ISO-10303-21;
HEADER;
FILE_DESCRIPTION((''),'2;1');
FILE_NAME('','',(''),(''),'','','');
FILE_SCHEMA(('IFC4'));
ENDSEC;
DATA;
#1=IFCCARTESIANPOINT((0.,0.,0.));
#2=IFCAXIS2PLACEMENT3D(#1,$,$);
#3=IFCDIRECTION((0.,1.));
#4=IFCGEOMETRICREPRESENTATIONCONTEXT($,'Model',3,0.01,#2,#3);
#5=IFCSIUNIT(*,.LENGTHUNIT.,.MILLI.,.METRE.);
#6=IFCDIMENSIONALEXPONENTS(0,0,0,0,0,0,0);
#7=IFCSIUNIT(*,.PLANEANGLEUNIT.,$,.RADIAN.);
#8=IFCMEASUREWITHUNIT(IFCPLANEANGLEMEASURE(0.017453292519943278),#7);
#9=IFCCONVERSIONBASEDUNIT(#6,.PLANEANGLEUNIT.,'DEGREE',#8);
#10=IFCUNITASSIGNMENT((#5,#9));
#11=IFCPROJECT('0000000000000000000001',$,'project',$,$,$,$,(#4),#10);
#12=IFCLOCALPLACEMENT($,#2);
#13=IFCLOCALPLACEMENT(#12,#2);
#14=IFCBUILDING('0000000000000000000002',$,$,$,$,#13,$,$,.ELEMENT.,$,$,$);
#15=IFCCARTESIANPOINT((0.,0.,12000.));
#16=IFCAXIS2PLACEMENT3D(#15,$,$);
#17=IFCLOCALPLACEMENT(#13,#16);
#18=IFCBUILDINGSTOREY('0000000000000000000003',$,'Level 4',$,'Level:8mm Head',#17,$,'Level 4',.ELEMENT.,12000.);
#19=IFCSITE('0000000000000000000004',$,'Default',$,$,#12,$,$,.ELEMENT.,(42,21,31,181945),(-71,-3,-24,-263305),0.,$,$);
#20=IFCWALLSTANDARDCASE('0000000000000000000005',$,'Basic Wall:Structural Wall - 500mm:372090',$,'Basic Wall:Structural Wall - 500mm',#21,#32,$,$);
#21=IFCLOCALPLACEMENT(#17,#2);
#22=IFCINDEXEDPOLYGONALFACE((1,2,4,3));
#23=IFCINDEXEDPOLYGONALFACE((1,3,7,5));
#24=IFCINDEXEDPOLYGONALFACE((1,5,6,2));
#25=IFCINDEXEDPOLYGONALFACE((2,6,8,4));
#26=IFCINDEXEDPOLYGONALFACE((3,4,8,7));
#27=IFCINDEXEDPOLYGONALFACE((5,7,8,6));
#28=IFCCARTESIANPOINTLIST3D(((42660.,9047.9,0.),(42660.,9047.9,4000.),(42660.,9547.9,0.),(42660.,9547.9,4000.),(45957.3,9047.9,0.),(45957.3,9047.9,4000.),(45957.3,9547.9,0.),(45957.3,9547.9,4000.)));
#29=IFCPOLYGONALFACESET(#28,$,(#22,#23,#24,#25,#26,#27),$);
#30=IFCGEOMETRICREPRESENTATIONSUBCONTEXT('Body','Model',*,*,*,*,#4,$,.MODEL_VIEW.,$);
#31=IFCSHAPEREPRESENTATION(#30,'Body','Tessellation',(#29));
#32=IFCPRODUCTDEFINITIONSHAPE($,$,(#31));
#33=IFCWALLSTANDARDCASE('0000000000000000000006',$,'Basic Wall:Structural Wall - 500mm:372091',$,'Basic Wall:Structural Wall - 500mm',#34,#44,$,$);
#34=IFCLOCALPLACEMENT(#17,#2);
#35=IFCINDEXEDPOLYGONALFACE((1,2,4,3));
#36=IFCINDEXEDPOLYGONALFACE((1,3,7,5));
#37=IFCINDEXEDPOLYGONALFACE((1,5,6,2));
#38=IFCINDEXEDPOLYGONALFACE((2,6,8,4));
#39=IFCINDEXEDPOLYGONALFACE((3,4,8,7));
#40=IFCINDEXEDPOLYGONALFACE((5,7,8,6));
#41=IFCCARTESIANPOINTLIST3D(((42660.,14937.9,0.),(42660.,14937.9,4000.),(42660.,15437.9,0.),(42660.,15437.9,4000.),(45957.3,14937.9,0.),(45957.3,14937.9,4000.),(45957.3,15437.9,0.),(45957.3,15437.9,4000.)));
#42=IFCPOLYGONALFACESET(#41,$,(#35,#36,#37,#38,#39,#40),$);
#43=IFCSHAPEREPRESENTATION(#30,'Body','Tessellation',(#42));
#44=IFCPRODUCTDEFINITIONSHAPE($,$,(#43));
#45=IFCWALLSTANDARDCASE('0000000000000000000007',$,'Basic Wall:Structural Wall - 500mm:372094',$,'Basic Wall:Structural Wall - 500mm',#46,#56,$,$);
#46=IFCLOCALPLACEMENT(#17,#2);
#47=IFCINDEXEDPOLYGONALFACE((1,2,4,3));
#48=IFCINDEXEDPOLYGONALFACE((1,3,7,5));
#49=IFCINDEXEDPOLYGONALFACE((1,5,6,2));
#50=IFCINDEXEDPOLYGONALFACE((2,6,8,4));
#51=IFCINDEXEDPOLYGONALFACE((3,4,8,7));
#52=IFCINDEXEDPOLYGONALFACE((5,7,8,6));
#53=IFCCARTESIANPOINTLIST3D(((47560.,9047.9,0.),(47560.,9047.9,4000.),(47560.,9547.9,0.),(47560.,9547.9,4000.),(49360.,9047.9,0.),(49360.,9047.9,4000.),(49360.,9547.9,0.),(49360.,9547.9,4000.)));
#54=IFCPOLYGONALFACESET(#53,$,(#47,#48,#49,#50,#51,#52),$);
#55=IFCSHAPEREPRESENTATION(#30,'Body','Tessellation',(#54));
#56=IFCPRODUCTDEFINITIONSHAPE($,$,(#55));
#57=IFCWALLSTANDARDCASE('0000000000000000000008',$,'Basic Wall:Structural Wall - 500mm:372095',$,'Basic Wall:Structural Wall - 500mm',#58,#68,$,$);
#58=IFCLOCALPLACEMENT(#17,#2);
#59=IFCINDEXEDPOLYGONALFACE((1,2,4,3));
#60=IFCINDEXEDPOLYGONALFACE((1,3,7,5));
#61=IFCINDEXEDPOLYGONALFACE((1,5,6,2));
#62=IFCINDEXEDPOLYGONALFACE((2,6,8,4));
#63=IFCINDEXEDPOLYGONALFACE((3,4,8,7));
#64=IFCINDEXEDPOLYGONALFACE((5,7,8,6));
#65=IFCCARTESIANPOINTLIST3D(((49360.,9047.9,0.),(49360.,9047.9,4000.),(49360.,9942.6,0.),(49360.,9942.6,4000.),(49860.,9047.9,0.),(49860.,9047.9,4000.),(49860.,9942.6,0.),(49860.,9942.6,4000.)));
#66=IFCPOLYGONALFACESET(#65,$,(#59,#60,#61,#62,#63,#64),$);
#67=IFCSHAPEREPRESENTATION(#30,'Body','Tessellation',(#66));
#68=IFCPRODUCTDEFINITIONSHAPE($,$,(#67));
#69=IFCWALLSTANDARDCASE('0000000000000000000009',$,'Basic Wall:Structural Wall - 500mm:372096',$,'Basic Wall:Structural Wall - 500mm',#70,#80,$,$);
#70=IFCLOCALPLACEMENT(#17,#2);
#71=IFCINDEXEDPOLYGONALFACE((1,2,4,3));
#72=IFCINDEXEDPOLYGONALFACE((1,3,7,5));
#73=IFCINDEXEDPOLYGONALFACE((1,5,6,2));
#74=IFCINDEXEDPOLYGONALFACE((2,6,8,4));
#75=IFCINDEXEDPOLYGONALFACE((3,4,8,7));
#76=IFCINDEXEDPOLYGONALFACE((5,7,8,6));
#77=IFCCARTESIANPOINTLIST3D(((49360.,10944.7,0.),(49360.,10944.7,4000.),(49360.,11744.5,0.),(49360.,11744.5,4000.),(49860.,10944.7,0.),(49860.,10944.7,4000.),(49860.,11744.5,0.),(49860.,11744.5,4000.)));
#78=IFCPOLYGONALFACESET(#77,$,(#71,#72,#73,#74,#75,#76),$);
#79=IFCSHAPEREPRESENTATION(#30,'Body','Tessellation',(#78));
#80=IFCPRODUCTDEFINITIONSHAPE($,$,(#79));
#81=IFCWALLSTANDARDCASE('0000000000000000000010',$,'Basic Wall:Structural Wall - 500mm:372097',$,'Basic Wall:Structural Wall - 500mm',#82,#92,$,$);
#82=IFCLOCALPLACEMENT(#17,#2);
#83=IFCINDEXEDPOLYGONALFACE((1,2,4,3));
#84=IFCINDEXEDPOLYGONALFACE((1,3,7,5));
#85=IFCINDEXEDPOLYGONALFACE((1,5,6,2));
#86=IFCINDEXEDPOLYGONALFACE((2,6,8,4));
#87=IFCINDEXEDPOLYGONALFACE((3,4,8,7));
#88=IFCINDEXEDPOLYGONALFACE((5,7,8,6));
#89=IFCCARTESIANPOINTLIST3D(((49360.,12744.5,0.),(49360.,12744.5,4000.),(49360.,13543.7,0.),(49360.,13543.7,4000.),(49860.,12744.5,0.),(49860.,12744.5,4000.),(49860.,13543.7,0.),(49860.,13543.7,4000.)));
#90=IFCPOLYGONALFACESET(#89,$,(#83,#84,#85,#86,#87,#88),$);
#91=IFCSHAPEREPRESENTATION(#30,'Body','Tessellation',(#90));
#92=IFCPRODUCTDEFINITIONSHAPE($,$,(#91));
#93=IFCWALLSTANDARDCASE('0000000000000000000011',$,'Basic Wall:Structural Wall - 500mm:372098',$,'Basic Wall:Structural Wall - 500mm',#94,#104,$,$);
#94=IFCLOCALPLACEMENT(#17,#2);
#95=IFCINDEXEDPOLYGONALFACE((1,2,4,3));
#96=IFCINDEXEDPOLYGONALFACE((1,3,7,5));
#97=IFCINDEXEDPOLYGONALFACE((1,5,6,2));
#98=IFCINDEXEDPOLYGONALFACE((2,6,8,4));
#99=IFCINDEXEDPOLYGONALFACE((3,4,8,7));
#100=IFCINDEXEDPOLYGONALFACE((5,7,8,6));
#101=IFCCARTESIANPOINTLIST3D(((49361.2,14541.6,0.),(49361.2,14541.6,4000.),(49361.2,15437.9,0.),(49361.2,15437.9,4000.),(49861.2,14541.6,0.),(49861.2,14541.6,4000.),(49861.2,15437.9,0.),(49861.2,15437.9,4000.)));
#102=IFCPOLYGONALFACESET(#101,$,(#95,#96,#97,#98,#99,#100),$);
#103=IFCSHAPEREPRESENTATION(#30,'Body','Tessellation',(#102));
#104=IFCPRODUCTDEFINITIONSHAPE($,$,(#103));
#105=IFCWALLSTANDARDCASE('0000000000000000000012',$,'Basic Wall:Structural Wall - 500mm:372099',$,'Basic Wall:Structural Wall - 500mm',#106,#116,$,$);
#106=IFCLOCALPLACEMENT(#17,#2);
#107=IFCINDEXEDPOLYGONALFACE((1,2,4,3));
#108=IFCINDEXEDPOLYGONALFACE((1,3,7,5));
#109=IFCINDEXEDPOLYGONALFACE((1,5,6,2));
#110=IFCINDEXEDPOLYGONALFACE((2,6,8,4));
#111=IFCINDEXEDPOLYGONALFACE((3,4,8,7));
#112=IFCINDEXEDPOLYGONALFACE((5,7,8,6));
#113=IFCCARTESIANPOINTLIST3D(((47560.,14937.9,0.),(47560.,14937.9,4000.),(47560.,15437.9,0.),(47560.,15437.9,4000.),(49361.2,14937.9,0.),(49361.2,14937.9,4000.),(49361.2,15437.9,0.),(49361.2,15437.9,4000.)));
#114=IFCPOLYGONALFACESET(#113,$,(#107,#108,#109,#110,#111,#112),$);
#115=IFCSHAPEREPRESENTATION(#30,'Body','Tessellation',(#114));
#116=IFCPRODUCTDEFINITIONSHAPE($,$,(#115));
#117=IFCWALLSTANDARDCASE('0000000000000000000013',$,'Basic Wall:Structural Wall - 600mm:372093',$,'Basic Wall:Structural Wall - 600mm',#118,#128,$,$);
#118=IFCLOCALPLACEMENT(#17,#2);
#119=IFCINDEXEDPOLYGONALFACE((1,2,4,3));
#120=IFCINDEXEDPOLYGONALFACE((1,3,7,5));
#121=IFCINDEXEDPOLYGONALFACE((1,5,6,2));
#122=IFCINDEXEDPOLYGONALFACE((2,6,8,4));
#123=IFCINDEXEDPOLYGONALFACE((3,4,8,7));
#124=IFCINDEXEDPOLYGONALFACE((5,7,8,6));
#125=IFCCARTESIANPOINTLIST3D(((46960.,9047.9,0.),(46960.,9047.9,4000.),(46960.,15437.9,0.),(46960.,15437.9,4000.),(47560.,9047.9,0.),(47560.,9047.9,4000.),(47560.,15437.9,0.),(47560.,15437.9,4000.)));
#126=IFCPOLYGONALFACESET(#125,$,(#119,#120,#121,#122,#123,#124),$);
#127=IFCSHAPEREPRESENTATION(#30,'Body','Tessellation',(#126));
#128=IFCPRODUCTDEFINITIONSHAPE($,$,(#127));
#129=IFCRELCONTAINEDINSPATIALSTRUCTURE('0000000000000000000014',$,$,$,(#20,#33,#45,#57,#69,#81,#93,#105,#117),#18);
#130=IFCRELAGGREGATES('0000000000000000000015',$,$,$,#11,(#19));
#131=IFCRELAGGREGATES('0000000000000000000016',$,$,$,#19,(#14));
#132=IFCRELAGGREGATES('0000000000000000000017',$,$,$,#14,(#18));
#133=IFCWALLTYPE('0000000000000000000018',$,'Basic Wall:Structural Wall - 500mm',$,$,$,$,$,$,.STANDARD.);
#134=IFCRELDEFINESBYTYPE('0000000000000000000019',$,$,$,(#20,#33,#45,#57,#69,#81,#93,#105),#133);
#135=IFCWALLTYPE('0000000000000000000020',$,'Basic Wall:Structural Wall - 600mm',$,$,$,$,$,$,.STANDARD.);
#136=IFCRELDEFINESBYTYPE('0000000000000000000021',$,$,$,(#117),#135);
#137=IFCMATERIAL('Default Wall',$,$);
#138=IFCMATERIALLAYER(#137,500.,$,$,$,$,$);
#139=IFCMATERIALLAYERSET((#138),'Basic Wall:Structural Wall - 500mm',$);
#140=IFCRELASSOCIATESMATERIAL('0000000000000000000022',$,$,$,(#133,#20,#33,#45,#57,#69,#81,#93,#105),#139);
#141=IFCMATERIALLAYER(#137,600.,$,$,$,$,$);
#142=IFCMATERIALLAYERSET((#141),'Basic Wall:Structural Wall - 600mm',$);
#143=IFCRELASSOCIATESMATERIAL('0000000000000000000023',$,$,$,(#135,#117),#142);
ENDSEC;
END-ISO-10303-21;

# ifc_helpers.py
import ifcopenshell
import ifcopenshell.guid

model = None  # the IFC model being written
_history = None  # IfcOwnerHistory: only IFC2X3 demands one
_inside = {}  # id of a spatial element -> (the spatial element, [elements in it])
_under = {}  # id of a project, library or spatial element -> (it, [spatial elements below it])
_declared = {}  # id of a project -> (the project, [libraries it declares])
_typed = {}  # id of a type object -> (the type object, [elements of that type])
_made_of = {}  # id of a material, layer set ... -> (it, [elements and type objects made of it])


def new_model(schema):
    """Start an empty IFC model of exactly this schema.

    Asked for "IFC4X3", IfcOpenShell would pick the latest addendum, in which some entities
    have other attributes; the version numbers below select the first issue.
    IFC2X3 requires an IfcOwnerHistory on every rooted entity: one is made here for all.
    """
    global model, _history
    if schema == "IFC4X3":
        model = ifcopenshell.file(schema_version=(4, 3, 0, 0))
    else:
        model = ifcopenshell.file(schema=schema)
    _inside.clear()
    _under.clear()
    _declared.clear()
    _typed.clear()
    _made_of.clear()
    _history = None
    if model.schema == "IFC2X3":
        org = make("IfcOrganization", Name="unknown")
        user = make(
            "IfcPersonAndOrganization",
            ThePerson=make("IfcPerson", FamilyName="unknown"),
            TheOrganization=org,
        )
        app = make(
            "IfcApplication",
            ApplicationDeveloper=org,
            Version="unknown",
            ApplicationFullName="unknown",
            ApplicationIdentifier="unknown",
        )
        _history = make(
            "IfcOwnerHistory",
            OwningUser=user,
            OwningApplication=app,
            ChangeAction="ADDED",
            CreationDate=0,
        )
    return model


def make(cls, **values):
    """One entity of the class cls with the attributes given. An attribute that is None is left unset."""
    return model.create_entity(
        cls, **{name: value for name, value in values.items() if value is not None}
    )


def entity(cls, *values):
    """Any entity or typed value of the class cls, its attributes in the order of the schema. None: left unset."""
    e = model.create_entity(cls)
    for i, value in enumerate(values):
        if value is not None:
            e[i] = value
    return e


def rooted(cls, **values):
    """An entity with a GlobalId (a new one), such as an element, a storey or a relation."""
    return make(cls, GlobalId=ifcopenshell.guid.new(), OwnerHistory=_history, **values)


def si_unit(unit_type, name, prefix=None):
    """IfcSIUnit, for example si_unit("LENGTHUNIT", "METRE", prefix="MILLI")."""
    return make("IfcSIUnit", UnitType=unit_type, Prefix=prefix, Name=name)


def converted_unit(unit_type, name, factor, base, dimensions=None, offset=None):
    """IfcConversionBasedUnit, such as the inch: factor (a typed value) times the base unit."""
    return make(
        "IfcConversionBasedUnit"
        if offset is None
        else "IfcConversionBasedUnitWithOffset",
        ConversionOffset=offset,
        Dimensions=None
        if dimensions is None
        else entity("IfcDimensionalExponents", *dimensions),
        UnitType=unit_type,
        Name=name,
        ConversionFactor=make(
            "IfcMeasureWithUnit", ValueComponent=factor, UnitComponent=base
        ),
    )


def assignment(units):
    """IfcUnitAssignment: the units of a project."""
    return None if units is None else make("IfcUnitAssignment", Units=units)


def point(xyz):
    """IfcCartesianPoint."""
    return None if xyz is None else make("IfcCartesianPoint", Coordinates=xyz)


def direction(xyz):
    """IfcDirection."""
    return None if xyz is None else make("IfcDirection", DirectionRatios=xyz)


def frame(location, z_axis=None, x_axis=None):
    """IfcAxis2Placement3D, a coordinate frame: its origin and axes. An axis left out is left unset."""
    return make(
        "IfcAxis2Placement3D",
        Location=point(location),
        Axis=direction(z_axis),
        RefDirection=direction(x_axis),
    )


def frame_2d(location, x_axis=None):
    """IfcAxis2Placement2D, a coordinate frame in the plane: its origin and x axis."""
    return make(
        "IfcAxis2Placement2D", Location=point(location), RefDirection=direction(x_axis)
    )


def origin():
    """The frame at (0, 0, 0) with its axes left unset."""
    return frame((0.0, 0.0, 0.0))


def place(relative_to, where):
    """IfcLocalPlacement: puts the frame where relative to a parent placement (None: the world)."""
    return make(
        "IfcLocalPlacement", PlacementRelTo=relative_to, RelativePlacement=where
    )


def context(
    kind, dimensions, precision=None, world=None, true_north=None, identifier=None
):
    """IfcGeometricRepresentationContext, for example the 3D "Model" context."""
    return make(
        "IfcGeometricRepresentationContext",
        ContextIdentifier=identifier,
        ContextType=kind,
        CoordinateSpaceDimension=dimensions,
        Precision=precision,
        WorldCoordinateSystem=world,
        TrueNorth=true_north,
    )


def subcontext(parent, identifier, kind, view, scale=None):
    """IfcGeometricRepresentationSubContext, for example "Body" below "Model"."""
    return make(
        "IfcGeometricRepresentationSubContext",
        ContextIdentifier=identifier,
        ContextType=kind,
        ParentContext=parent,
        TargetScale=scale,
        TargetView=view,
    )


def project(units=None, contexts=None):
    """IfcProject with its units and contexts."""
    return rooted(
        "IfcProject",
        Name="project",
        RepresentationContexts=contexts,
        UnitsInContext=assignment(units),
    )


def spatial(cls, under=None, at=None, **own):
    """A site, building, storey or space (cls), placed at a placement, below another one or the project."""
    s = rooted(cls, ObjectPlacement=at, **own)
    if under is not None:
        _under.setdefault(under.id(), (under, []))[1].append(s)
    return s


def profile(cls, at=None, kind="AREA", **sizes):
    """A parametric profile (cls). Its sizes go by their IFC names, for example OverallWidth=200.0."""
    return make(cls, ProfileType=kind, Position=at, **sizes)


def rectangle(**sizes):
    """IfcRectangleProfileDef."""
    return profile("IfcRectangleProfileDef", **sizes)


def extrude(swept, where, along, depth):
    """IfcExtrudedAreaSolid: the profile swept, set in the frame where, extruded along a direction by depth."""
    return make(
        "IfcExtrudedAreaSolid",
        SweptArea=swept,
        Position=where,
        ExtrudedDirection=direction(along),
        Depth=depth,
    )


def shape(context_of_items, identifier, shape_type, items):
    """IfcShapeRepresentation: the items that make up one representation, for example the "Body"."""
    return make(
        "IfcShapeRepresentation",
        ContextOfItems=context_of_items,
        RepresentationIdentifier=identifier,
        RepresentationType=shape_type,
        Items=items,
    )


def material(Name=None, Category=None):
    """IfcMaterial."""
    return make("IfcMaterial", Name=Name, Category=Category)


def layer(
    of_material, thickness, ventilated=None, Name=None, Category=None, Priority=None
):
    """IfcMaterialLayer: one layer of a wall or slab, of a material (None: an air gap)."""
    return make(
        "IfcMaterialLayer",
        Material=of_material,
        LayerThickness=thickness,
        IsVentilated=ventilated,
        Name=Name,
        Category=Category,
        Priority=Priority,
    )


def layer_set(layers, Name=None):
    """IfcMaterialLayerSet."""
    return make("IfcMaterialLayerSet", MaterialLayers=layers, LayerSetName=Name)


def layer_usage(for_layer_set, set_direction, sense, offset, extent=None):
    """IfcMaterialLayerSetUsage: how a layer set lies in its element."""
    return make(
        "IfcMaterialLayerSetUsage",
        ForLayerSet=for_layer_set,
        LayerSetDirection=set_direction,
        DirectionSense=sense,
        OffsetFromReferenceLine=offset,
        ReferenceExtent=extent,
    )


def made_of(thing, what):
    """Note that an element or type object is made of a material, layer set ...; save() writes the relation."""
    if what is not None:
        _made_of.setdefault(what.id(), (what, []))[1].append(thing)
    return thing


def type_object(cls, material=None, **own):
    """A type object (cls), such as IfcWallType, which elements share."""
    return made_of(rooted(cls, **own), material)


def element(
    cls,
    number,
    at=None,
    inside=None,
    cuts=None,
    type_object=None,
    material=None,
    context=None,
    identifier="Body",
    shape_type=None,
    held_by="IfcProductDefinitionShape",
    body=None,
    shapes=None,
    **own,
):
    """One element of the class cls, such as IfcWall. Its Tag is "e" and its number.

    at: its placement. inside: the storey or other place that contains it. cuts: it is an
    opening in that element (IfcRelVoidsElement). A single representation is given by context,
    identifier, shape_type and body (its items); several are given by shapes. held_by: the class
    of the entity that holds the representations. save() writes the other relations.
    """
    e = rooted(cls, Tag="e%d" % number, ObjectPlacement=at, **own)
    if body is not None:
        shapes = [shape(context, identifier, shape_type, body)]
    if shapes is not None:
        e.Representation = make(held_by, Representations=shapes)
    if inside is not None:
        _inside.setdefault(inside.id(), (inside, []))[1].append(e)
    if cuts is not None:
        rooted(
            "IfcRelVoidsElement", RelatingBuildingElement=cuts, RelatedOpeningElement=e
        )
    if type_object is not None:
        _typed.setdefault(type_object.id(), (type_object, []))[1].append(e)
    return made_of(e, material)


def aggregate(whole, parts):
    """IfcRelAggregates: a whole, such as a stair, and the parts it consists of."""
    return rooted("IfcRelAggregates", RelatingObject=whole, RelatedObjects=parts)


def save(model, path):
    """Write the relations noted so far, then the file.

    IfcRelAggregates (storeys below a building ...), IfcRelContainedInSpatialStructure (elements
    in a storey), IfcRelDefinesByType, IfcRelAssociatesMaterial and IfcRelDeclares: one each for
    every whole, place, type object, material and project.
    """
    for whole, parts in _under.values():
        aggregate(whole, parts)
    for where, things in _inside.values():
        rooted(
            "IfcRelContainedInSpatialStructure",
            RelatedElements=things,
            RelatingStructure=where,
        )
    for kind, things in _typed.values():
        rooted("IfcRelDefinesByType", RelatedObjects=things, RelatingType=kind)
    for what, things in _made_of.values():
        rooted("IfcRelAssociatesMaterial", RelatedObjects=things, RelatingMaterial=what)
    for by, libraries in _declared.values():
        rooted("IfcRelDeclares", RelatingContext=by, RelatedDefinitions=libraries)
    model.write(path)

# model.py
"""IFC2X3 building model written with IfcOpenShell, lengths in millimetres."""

from ifc_helpers import new_model, entity, si_unit, converted_unit, direction, frame, frame_2d, origin, place, context, subcontext, project, spatial, rectangle, extrude, material, layer, layer_set, layer_usage, type_object, element, save


model = new_model("IFC2X3")

# Units and contexts
model_context = context("Model", 3, precision=0.01, world=origin(), true_north=direction((0.0, 1.0)))
body_context = subcontext(model_context, "Body", "Model", "MODEL_VIEW")
ifc_project = project(units=[si_unit("LENGTHUNIT", "METRE", prefix="MILLI"), converted_unit("PLANEANGLEUNIT", "DEGREE", entity("IfcPlaneAngleMeasure", 0.017453292519943278), si_unit("PLANEANGLEUNIT", "RADIAN"), dimensions=[0, 0, 0, 0, 0, 0, 0])], contexts=[model_context])

# Site, building, storey
site_placement = place(None, origin())
site = spatial("IfcSite", under=ifc_project, at=site_placement, Name="Default", CompositionType="ELEMENT", RefLatitude=(42, 21, 31, 181945), RefLongitude=(-71, -3, -24, -263305), RefElevation=0.0)
building_placement = place(site_placement, origin())
building = spatial("IfcBuilding", under=site, at=building_placement, CompositionType="ELEMENT")
storey_placement = place(building_placement, frame((0.0, 0.0, 12000.0)))
storey = spatial("IfcBuildingStorey", under=building, at=storey_placement, Name="Level 4", ObjectType="Level:8mm Head", LongName="Level 4", CompositionType="ELEMENT", Elevation=12000.0)

# Walls
ifc_material = material(Name="Default Wall")
ifc_layer_1 = layer(ifc_material, 500.0)
ifc_layer_set_1 = layer_set([ifc_layer_1], Name="Basic Wall:Structural Wall - 500mm")
wall_type_1 = type_object("IfcWallType", Name="Basic Wall:Structural Wall - 500mm", PredefinedType="STANDARD", material=ifc_layer_set_1)
ifc_layer_usage_1 = layer_usage(ifc_layer_set_1, "AXIS2", "POSITIVE", -250.0)
wall_1_placement = place(storey_placement, frame((42660.0, 9297.9, 0.0)))
element("IfcWallStandardCase", 1, at=wall_1_placement, inside=storey, type_object=wall_type_1, material=ifc_layer_usage_1, Name="Basic Wall:Structural Wall - 500mm:372090", ObjectType="Basic Wall:Structural Wall - 500mm", context=body_context, shape_type="SweptSolid", body=[
    extrude(rectangle(XDim=3297.3, YDim=500.0, at=frame_2d((1648.6, 0.0), x_axis=(-1.0, 0.0))), origin(), (0.0, 0.0, 1.0), 4000.0),
])
ifc_layer_usage_2 = layer_usage(ifc_layer_set_1, "AXIS2", "NEGATIVE", 250.0)
wall_2_placement = place(storey_placement, frame((45957.3, 15187.9, 0.0), z_axis=(0.0, 0.0, 1.0), x_axis=(-1.0, 0.0, 0.0)))
element("IfcWallStandardCase", 2, at=wall_2_placement, inside=storey, type_object=wall_type_1, material=ifc_layer_usage_2, Name="Basic Wall:Structural Wall - 500mm:372091", ObjectType="Basic Wall:Structural Wall - 500mm", context=body_context, shape_type="SweptSolid", body=[
    extrude(rectangle(XDim=3297.3, YDim=500.0, at=frame_2d((1648.6, 0.0), x_axis=(-1.0, 0.0))), origin(), (0.0, 0.0, 1.0), 4000.0),
])
ifc_layer_usage_3 = layer_usage(ifc_layer_set_1, "AXIS2", "POSITIVE", -250.0)
wall_3_placement = place(storey_placement, frame((47560.0, 9297.9, 0.0)))
element("IfcWallStandardCase", 3, at=wall_3_placement, inside=storey, type_object=wall_type_1, material=ifc_layer_usage_3, Name="Basic Wall:Structural Wall - 500mm:372094", ObjectType="Basic Wall:Structural Wall - 500mm", context=body_context, shape_type="SweptSolid", body=[
    extrude(rectangle(XDim=1800.0, YDim=500.0, at=frame_2d((900.0, 0.0), x_axis=(-1.0, 0.0))), origin(), (0.0, 0.0, 1.0), 4000.0),
])
ifc_layer_usage_4 = layer_usage(ifc_layer_set_1, "AXIS2", "NEGATIVE", 250.0)
wall_4_placement = place(storey_placement, frame((49610.0, 9047.9, 0.0), z_axis=(0.0, 0.0, 1.0), x_axis=(0.0, 1.0, 0.0)))
element("IfcWallStandardCase", 4, at=wall_4_placement, inside=storey, type_object=wall_type_1, material=ifc_layer_usage_4, Name="Basic Wall:Structural Wall - 500mm:372095", ObjectType="Basic Wall:Structural Wall - 500mm", context=body_context, shape_type="SweptSolid", body=[
    extrude(rectangle(XDim=894.7, YDim=500.0, at=frame_2d((447.3, 0.0), x_axis=(-1.0, 0.0))), origin(), (0.0, 0.0, 1.0), 4000.0),
])
ifc_layer_usage_5 = layer_usage(ifc_layer_set_1, "AXIS2", "NEGATIVE", 250.0)
wall_5_placement = place(storey_placement, frame((49610.0, 10944.7, 0.0), z_axis=(0.0, 0.0, 1.0), x_axis=(0.0, 1.0, 0.0)))
element("IfcWallStandardCase", 5, at=wall_5_placement, inside=storey, type_object=wall_type_1, material=ifc_layer_usage_5, Name="Basic Wall:Structural Wall - 500mm:372096", ObjectType="Basic Wall:Structural Wall - 500mm", context=body_context, shape_type="SweptSolid", body=[
    extrude(rectangle(XDim=799.8, YDim=500.0, at=frame_2d((399.9, 0.0), x_axis=(-1.0, 0.0))), origin(), (0.0, 0.0, 1.0), 4000.0),
])
ifc_layer_usage_6 = layer_usage(ifc_layer_set_1, "AXIS2", "NEGATIVE", 250.0)
wall_6_placement = place(storey_placement, frame((49610.0, 12744.5, 0.0), z_axis=(0.0, 0.0, 1.0), x_axis=(0.0, 1.0, 0.0)))
element("IfcWallStandardCase", 6, at=wall_6_placement, inside=storey, type_object=wall_type_1, material=ifc_layer_usage_6, Name="Basic Wall:Structural Wall - 500mm:372097", ObjectType="Basic Wall:Structural Wall - 500mm", context=body_context, shape_type="SweptSolid", body=[
    extrude(rectangle(XDim=799.2, YDim=500.0, at=frame_2d((399.6, 0.0), x_axis=(-1.0, 0.0))), origin(), (0.0, 0.0, 1.0), 4000.0),
])
ifc_layer_usage_7 = layer_usage(ifc_layer_set_1, "AXIS2", "NEGATIVE", 250.0)
wall_7_placement = place(storey_placement, frame((49611.2, 14541.6, 0.0), z_axis=(0.0, 0.0, 1.0), x_axis=(0.0, 1.0, 0.0)))
element("IfcWallStandardCase", 7, at=wall_7_placement, inside=storey, type_object=wall_type_1, material=ifc_layer_usage_7, Name="Basic Wall:Structural Wall - 500mm:372098", ObjectType="Basic Wall:Structural Wall - 500mm", context=body_context, shape_type="SweptSolid", body=[
    extrude(rectangle(XDim=896.3, YDim=500.0, at=frame_2d((448.2, 0.0), x_axis=(-1.0, 0.0))), origin(), (0.0, 0.0, 1.0), 4000.0),
])
ifc_layer_usage_8 = layer_usage(ifc_layer_set_1, "AXIS2", "NEGATIVE", 250.0)
wall_8_placement = place(storey_placement, frame((49361.2, 15187.9, 0.0), z_axis=(0.0, 0.0, 1.0), x_axis=(-1.0, 0.0, 0.0)))
element("IfcWallStandardCase", 8, at=wall_8_placement, inside=storey, type_object=wall_type_1, material=ifc_layer_usage_8, Name="Basic Wall:Structural Wall - 500mm:372099", ObjectType="Basic Wall:Structural Wall - 500mm", context=body_context, shape_type="SweptSolid", body=[
    extrude(rectangle(XDim=1801.2, YDim=500.0, at=frame_2d((900.6, 0.0), x_axis=(-1.0, 0.0))), origin(), (0.0, 0.0, 1.0), 4000.0),
])
ifc_layer_2 = layer(ifc_material, 600.0)
ifc_layer_set_2 = layer_set([ifc_layer_2], Name="Basic Wall:Structural Wall - 600mm")
ifc_layer_usage_9 = layer_usage(ifc_layer_set_2, "AXIS2", "NEGATIVE", 300.0)
wall_type_2 = type_object("IfcWallType", Name="Basic Wall:Structural Wall - 600mm", PredefinedType="STANDARD", material=ifc_layer_set_2)
wall_9_placement = place(storey_placement, frame((47260.0, 15437.9, 0.0), z_axis=(0.0, 0.0, 1.0), x_axis=(0.0, -1.0, 0.0)))
element("IfcWallStandardCase", 9, at=wall_9_placement, inside=storey, type_object=wall_type_2, material=ifc_layer_usage_9, Name="Basic Wall:Structural Wall - 600mm:372093", ObjectType="Basic Wall:Structural Wall - 600mm", context=body_context, shape_type="SweptSolid", body=[
    extrude(rectangle(XDim=6390.0, YDim=600.0, at=frame_2d((3195.0, 0.0), x_axis=(-1.0, 0.0))), origin(), (0.0, 0.0, 1.0), 4000.0),
])

save(model, "model.ifc")
